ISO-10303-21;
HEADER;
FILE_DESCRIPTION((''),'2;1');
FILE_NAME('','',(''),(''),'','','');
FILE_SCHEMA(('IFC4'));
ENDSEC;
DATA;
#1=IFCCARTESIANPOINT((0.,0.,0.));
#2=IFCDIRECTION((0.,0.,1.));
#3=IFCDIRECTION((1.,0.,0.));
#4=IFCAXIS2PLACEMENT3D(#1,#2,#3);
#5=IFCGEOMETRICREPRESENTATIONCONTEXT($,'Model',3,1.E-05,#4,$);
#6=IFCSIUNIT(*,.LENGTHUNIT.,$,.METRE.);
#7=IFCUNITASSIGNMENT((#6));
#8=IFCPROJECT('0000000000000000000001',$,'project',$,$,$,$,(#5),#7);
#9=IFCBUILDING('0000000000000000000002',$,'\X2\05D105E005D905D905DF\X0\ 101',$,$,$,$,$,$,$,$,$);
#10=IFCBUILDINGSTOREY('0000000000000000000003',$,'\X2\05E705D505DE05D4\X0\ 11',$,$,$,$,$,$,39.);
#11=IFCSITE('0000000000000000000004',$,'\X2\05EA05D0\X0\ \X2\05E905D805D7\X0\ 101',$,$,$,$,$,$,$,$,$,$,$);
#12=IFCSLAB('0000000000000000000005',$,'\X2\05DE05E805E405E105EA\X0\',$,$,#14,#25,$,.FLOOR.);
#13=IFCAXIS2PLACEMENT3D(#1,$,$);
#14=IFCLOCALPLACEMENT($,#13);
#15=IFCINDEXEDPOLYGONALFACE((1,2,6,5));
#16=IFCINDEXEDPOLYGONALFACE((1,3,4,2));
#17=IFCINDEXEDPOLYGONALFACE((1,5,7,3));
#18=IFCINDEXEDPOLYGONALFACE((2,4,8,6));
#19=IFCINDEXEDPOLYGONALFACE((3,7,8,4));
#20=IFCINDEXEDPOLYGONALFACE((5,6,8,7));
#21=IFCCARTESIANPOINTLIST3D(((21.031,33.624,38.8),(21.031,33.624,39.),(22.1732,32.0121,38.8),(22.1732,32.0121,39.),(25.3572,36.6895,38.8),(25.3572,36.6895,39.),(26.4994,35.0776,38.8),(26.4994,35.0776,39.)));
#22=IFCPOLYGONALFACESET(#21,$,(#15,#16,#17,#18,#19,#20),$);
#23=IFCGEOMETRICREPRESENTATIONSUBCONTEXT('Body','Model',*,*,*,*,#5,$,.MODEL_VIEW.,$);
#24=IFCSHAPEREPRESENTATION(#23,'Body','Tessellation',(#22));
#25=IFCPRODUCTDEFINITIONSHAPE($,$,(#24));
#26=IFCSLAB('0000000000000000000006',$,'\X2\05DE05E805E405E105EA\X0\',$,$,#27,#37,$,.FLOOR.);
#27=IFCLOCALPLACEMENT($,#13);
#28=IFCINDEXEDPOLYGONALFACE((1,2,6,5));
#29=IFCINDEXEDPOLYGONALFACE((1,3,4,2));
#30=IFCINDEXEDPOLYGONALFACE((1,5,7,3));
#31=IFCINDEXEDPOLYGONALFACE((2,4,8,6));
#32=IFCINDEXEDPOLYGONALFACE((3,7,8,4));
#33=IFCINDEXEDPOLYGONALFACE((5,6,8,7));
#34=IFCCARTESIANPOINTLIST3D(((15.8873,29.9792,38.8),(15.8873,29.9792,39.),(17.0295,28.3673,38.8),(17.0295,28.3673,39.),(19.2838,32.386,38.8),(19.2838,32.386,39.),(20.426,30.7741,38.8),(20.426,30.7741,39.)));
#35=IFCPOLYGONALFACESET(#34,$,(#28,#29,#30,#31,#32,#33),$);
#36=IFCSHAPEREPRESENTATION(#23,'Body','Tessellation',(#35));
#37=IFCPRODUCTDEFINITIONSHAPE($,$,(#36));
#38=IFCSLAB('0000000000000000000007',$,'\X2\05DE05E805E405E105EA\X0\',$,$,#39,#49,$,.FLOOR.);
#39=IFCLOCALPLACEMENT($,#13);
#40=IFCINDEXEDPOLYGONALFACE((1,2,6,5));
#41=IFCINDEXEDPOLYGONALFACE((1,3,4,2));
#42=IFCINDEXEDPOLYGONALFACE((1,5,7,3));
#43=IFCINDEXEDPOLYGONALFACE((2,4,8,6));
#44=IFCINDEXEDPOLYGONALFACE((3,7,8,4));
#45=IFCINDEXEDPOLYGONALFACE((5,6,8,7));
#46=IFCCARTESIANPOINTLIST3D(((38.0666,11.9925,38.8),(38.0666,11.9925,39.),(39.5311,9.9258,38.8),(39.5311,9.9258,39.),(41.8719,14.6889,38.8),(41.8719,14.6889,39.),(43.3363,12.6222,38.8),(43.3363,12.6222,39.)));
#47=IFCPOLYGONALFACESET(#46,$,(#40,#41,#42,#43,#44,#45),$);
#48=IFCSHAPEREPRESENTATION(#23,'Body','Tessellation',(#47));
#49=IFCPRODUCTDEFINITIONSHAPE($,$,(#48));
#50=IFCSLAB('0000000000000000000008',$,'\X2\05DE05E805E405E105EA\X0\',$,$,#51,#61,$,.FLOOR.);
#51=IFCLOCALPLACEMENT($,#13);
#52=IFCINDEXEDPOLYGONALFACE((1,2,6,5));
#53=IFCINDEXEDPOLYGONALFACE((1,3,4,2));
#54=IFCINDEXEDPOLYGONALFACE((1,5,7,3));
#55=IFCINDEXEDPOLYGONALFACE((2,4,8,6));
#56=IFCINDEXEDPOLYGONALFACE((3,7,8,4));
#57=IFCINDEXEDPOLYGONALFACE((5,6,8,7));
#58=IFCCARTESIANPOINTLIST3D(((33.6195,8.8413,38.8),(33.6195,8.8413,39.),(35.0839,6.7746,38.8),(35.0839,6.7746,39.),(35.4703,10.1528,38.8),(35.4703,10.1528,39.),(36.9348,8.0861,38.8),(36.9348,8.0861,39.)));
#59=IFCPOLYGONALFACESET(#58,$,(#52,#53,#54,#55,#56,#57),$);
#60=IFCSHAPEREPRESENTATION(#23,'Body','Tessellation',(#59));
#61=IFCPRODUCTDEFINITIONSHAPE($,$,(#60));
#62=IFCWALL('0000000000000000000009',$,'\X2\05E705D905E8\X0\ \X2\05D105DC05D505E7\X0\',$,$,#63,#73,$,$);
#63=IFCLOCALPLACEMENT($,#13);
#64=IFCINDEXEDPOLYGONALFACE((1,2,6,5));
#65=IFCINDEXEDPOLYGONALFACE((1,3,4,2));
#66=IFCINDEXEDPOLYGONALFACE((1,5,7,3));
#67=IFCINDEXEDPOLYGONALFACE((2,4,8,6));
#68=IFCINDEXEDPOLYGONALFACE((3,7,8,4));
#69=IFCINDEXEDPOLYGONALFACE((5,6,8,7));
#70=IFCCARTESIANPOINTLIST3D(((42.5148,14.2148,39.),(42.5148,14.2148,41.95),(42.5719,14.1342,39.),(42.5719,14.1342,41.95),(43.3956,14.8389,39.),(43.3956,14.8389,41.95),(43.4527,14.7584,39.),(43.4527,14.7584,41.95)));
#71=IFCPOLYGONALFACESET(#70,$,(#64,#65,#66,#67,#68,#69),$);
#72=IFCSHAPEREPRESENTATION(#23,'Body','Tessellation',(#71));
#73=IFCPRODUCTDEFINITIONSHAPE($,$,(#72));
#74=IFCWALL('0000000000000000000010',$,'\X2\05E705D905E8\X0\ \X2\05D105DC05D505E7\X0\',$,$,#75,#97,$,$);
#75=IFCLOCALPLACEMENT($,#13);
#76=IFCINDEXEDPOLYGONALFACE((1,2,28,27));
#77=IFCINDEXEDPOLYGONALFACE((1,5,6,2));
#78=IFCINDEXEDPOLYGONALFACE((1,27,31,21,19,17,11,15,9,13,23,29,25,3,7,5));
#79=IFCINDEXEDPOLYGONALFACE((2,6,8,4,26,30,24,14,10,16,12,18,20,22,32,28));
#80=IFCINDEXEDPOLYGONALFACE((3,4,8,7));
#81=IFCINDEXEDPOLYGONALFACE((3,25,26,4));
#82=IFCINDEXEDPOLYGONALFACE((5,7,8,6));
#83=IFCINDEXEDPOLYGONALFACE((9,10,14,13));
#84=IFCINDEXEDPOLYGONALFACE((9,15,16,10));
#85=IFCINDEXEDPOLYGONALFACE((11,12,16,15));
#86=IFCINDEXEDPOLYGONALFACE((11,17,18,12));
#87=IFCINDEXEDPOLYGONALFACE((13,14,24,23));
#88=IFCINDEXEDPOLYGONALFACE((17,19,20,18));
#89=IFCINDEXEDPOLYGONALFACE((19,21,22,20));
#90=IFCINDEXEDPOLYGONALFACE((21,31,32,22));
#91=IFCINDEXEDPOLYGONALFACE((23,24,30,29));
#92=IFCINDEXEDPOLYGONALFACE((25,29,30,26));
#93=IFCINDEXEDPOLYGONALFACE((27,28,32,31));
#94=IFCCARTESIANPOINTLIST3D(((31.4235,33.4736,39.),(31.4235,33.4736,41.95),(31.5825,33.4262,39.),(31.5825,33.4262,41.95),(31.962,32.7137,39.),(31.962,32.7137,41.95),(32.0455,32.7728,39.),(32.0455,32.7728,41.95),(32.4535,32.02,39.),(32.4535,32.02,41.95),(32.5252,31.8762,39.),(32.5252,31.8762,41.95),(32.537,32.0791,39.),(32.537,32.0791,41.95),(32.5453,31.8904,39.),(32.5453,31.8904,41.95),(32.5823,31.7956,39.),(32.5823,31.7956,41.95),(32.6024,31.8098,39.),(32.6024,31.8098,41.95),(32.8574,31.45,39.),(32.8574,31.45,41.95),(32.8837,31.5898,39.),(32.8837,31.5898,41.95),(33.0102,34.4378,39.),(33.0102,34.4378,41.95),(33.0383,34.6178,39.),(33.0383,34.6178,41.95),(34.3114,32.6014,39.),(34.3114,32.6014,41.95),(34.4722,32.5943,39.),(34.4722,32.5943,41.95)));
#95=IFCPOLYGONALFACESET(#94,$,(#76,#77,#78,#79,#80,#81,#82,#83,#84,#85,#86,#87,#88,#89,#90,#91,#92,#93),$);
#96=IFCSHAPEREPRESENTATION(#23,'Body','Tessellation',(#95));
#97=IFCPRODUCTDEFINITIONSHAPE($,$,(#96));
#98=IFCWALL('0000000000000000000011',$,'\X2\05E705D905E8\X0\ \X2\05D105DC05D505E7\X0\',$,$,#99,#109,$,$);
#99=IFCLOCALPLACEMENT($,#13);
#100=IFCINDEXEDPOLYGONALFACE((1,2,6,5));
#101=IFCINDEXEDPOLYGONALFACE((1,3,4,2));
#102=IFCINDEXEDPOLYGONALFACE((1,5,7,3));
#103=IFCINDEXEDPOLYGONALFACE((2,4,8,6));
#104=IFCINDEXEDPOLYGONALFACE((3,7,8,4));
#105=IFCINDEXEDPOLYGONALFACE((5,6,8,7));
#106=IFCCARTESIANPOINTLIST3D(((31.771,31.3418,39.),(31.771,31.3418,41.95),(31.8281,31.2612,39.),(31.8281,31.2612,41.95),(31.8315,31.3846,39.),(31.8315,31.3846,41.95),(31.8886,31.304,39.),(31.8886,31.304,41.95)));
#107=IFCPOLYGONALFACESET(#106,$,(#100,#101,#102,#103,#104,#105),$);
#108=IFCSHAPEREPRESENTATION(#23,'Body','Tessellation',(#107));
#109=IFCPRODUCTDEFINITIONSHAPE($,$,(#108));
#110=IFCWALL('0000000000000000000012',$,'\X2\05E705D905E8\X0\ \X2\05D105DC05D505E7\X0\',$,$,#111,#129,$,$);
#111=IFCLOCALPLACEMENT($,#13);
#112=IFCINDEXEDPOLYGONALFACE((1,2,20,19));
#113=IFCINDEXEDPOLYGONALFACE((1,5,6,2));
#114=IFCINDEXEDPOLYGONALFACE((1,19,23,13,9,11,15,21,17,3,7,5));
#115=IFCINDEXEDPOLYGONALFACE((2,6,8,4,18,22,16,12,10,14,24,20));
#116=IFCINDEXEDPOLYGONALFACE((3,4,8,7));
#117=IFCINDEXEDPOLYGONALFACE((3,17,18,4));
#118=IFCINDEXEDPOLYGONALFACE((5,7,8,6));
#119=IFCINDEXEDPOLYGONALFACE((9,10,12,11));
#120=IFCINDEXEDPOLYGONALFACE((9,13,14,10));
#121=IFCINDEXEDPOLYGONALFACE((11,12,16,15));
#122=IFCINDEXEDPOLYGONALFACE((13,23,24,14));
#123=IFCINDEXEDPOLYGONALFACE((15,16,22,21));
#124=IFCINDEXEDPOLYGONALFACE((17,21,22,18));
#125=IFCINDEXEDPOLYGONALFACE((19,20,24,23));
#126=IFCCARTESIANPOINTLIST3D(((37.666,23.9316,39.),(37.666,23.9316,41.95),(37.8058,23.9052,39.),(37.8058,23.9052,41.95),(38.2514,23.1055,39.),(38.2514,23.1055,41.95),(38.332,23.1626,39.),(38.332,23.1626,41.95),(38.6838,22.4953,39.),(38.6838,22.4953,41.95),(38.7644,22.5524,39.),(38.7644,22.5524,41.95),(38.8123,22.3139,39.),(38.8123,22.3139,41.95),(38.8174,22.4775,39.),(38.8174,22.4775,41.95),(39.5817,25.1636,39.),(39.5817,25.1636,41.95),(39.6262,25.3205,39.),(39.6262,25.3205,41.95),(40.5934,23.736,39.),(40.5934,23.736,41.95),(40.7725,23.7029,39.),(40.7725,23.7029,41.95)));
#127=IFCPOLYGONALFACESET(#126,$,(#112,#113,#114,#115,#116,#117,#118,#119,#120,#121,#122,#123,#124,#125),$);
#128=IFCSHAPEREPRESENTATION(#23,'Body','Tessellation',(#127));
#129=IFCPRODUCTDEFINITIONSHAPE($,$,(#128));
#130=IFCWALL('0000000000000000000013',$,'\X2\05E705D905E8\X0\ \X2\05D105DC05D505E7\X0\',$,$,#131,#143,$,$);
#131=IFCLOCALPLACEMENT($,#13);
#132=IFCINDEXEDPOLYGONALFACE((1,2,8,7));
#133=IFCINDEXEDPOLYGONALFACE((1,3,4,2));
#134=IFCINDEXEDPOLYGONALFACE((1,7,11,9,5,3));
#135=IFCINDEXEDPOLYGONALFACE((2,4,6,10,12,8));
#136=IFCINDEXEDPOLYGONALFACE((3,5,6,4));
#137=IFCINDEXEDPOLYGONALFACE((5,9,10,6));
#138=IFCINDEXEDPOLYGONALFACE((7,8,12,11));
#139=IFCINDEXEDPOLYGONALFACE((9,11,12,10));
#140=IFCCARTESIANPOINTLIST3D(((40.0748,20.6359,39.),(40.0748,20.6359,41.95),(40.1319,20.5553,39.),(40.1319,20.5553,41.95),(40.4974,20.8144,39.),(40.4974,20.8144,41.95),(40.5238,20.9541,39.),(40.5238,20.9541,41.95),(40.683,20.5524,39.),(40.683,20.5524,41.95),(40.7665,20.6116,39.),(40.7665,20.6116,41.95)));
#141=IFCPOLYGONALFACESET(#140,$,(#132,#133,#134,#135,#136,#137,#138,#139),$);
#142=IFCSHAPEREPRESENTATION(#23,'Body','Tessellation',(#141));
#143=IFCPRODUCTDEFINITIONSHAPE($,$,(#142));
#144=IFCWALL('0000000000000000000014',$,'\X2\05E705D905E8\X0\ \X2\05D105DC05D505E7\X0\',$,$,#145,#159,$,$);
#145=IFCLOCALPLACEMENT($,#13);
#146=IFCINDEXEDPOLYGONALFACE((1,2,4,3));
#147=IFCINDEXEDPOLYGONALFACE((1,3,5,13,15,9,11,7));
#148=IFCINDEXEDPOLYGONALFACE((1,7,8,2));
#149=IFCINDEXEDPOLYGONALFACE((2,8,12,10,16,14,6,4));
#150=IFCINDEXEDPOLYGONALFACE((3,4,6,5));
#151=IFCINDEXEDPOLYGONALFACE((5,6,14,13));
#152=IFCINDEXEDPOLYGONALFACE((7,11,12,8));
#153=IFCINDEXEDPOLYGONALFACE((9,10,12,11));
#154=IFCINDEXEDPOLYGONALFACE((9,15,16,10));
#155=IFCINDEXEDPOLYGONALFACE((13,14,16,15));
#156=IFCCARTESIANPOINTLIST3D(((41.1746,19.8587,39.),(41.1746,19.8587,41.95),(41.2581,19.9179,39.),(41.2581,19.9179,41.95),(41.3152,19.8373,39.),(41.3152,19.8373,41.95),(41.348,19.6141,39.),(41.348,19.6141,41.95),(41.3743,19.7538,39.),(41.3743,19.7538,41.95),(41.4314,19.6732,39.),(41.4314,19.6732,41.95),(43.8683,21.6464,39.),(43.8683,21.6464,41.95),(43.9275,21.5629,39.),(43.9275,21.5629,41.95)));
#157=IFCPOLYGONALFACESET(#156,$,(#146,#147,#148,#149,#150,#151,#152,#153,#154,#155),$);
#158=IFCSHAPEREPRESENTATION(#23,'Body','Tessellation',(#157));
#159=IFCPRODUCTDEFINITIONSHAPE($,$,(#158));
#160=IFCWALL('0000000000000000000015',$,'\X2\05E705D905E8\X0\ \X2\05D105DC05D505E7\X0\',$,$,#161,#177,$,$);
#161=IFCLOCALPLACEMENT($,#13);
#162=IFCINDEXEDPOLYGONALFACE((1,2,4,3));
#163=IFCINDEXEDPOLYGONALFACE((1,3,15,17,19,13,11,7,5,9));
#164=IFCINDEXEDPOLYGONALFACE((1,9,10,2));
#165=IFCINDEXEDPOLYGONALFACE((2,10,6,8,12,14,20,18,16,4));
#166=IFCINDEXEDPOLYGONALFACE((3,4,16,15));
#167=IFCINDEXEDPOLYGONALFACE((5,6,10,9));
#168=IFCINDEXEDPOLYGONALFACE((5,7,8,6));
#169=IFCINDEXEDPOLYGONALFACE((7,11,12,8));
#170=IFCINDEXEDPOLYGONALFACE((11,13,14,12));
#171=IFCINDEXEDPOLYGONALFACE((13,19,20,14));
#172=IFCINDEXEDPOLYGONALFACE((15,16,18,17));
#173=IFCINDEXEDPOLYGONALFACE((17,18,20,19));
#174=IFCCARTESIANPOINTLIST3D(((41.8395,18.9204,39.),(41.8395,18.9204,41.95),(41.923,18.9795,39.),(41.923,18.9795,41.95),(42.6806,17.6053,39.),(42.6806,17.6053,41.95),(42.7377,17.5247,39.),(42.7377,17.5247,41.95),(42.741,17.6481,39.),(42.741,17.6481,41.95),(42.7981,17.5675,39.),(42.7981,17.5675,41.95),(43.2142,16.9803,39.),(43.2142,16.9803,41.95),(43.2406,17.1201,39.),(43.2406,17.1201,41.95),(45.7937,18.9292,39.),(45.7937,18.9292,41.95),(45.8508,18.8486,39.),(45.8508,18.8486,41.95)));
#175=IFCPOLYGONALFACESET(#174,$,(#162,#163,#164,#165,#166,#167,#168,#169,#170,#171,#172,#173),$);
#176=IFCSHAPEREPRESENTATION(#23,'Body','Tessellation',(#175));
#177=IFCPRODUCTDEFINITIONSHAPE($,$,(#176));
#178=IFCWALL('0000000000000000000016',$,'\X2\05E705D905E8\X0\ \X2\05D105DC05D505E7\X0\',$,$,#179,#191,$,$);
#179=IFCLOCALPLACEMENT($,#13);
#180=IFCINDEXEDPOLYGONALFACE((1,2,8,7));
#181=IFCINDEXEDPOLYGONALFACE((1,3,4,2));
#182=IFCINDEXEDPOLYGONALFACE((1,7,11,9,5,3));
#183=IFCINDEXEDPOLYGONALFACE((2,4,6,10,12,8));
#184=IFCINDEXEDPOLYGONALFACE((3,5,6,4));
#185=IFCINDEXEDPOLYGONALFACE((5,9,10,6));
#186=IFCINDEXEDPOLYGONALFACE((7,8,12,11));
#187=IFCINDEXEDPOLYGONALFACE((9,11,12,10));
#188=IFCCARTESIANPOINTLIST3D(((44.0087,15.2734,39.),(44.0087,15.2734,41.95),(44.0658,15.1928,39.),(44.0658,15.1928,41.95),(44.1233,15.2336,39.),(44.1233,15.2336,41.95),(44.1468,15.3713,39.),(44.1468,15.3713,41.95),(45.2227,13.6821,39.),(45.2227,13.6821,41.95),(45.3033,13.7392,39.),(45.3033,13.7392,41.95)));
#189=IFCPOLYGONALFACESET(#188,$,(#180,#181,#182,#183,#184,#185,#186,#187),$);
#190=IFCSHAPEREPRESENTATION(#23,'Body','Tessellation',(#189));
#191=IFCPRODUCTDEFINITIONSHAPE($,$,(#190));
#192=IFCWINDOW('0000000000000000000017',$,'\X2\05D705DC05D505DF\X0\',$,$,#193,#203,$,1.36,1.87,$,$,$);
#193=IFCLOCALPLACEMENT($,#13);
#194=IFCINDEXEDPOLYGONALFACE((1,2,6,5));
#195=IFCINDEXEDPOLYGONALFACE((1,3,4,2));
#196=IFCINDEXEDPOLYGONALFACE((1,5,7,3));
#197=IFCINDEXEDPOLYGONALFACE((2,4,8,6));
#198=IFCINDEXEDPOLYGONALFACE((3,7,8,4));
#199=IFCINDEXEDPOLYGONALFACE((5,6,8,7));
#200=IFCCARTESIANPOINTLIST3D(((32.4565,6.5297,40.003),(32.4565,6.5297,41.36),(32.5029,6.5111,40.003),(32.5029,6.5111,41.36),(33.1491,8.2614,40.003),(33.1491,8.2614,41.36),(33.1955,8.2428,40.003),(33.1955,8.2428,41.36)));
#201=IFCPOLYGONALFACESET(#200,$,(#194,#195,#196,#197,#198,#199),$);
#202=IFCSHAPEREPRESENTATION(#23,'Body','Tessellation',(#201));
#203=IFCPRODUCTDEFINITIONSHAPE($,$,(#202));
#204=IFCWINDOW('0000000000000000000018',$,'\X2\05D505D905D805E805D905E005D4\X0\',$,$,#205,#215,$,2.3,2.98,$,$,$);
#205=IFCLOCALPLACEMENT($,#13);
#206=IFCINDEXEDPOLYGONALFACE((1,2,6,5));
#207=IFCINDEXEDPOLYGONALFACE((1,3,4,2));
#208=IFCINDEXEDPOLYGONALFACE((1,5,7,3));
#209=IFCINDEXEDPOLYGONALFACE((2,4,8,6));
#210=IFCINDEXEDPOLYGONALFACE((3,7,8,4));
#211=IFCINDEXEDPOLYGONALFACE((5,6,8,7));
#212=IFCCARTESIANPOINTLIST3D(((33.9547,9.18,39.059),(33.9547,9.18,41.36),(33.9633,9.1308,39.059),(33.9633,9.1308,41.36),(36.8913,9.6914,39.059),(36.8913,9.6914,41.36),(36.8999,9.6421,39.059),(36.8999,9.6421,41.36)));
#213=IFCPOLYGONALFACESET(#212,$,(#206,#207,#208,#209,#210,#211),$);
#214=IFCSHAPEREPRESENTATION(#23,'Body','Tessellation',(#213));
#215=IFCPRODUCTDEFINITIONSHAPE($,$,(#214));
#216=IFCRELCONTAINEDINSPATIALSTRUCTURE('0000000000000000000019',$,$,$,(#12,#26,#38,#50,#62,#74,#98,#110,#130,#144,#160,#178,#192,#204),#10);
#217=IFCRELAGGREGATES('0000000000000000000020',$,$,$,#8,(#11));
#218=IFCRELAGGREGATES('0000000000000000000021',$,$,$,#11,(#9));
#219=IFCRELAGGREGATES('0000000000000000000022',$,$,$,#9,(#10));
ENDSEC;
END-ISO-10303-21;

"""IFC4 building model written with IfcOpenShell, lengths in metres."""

from ifc_helpers import new_model, si_unit, frame, origin_with_axes, context, subcontext, project, spatial, polyline, outline, extrude, element, save


model = new_model("IFC4")

# Units and contexts
model_context = context("Model", 3, precision=1e-05, world=origin_with_axes())
body_context = subcontext(model_context, "Body", "Model", "MODEL_VIEW")
ifc_project = project(units=[si_unit("LENGTHUNIT", "METRE")], contexts=[model_context])

# Site, building, storey
site = spatial("IfcSite", under=ifc_project, Name="תא שטח 101")
building = spatial("IfcBuilding", under=site, Name="בניין 101")
storey = spatial("IfcBuildingStorey", under=building, Name="קומה 11", Elevation=39.0)

# Slabs
element("IfcSlab", 1, inside=storey, Name="מרפסת", PredefinedType="FLOOR", context=body_context, shape_type="SweptSolid", body=[
    extrude(outline(polyline([(21.031, 33.624), (25.3572, 36.6895), (26.4994, 35.0776), (22.1732, 32.0121), (21.031, 33.624)])), frame((0.0, 0.0, 38.8)), (0.0, 0.0, 1.0), 0.2),
])
element("IfcSlab", 2, inside=storey, Name="מרפסת", PredefinedType="FLOOR", context=body_context, shape_type="SweptSolid", body=[
    extrude(outline(polyline([(15.8873, 29.9792), (19.2838, 32.386), (20.426, 30.7741), (17.0295, 28.3673), (15.8873, 29.9792)])), frame((0.0, 0.0, 38.8)), (0.0, 0.0, 1.0), 0.2),
])
element("IfcSlab", 3, inside=storey, Name="מרפסת", PredefinedType="FLOOR", context=body_context, shape_type="SweptSolid", body=[
    extrude(outline(polyline([(38.0666, 11.9925), (41.8719, 14.6889), (43.3363, 12.6222), (39.5311, 9.9258), (38.0666, 11.9925)])), frame((0.0, 0.0, 38.8)), (0.0, 0.0, 1.0), 0.2),
])
element("IfcSlab", 4, inside=storey, Name="מרפסת", PredefinedType="FLOOR", context=body_context, shape_type="SweptSolid", body=[
    extrude(outline(polyline([(33.6195, 8.8413), (35.4703, 10.1528), (36.9348, 8.0861), (35.0839, 6.7746), (33.6195, 8.8413)])), frame((0.0, 0.0, 38.8)), (0.0, 0.0, 1.0), 0.2),
])

# Walls
element("IfcWall", 5, inside=storey, Name="קיר בלוק", context=body_context, shape_type="SweptSolid", body=[
    extrude(outline(polyline([(43.4527, 14.7584), (43.3956, 14.8389), (42.5148, 14.2148), (42.5719, 14.1342), (43.4527, 14.7584)])), frame((0.0, 0.0, 39.0)), (0.0, 0.0, 1.0), 2.95),
])
element("IfcWall", 6, inside=storey, Name="קיר בלוק", context=body_context, shape_type="SweptSolid", body=[
    extrude(outline(polyline([(31.5825, 33.4262), (33.0102, 34.4378), (34.3114, 32.6014), (32.8837, 31.5898), (32.537, 32.0791), (32.4535, 32.02), (32.5453, 31.8904), (32.5252, 31.8762), (32.5823, 31.7956), (32.6024, 31.8098), (32.8574, 31.45), (34.4722, 32.5943), (33.0383, 34.6178), (31.4235, 33.4736), (31.962, 32.7137), (32.0455, 32.7728), (31.5825, 33.4262)])), frame((0.0, 0.0, 39.0)), (0.0, 0.0, 1.0), 2.95),
])
element("IfcWall", 7, inside=storey, Name="קיר בלוק", context=body_context, shape_type="SweptSolid", body=[
    extrude(outline(polyline([(31.8315, 31.3846), (31.771, 31.3418), (31.8281, 31.2612), (31.8886, 31.304), (31.8315, 31.3846)])), frame((0.0, 0.0, 39.0)), (0.0, 0.0, 1.0), 2.95),
])
element("IfcWall", 8, inside=storey, Name="קיר בלוק", context=body_context, shape_type="SweptSolid", body=[
    extrude(outline(polyline([(38.332, 23.1626), (37.8058, 23.9052), (39.5817, 25.1636), (40.5934, 23.736), (38.8174, 22.4775), (38.7644, 22.5524), (38.6838, 22.4953), (38.8123, 22.3139), (40.7725, 23.7029), (39.6262, 25.3205), (37.666, 23.9316), (38.2514, 23.1055), (38.332, 23.1626)])), frame((0.0, 0.0, 39.0)), (0.0, 0.0, 1.0), 2.95),
])
element("IfcWall", 9, inside=storey, Name="קיר בלוק", context=body_context, shape_type="SweptSolid", body=[
    extrude(outline(polyline([(40.683, 20.5524), (40.7665, 20.6116), (40.5238, 20.9541), (40.0748, 20.6359), (40.1319, 20.5553), (40.4974, 20.8144), (40.683, 20.5524)])), frame((0.0, 0.0, 39.0)), (0.0, 0.0, 1.0), 2.95),
])
element("IfcWall", 10, inside=storey, Name="קיר בלוק", context=body_context, shape_type="SweptSolid", body=[
    extrude(outline(polyline([(41.3152, 19.8373), (41.2581, 19.9179), (41.1746, 19.8587), (41.348, 19.6141), (41.4314, 19.6732), (41.3743, 19.7538), (43.9275, 21.5629), (43.8683, 21.6464), (41.3152, 19.8373)])), frame((0.0, 0.0, 39.0)), (0.0, 0.0, 1.0), 2.95),
])
element("IfcWall", 11, inside=storey, Name="קיר בלוק", context=body_context, shape_type="SweptSolid", body=[
    extrude(outline(polyline([(42.7981, 17.5675), (43.2142, 16.9803), (45.8508, 18.8486), (45.7937, 18.9292), (43.2406, 17.1201), (41.923, 18.9795), (41.8395, 18.9204), (42.741, 17.6481), (42.6806, 17.6053), (42.7377, 17.5247), (42.7981, 17.5675)])), frame((0.0, 0.0, 39.0)), (0.0, 0.0, 1.0), 2.95),
])
element("IfcWall", 12, inside=storey, Name="קיר בלוק", context=body_context, shape_type="SweptSolid", body=[
    extrude(outline(polyline([(44.1468, 15.3713), (44.0087, 15.2734), (44.0658, 15.1928), (44.1233, 15.2336), (45.2227, 13.6821), (45.3033, 13.7392), (44.1468, 15.3713)])), frame((0.0, 0.0, 39.0)), (0.0, 0.0, 1.0), 2.95),
])

# Windows
element("IfcWindow", 13, inside=storey, Name="חלון", OverallHeight=1.36, OverallWidth=1.87, context=body_context, shape_type="SweptSolid", body=[
    extrude(outline(polyline([(32.5029, 6.5111), (33.1955, 8.2428), (33.1491, 8.2614), (32.4565, 6.5297), (32.5029, 6.5111)])), frame((0.0, 0.0, 40.003)), (0.0, 0.0, 1.0), 1.357),
])
element("IfcWindow", 14, inside=storey, Name="ויטרינה", OverallHeight=2.3, OverallWidth=2.98, context=body_context, shape_type="SweptSolid", body=[
    extrude(outline(polyline([(33.9633, 9.1308), (36.8999, 9.6421), (36.8913, 9.6914), (33.9547, 9.18), (33.9633, 9.1308)])), frame((0.0, 0.0, 39.059)), (0.0, 0.0, 1.0), 2.301),
])

save(model, "model.ifc")
